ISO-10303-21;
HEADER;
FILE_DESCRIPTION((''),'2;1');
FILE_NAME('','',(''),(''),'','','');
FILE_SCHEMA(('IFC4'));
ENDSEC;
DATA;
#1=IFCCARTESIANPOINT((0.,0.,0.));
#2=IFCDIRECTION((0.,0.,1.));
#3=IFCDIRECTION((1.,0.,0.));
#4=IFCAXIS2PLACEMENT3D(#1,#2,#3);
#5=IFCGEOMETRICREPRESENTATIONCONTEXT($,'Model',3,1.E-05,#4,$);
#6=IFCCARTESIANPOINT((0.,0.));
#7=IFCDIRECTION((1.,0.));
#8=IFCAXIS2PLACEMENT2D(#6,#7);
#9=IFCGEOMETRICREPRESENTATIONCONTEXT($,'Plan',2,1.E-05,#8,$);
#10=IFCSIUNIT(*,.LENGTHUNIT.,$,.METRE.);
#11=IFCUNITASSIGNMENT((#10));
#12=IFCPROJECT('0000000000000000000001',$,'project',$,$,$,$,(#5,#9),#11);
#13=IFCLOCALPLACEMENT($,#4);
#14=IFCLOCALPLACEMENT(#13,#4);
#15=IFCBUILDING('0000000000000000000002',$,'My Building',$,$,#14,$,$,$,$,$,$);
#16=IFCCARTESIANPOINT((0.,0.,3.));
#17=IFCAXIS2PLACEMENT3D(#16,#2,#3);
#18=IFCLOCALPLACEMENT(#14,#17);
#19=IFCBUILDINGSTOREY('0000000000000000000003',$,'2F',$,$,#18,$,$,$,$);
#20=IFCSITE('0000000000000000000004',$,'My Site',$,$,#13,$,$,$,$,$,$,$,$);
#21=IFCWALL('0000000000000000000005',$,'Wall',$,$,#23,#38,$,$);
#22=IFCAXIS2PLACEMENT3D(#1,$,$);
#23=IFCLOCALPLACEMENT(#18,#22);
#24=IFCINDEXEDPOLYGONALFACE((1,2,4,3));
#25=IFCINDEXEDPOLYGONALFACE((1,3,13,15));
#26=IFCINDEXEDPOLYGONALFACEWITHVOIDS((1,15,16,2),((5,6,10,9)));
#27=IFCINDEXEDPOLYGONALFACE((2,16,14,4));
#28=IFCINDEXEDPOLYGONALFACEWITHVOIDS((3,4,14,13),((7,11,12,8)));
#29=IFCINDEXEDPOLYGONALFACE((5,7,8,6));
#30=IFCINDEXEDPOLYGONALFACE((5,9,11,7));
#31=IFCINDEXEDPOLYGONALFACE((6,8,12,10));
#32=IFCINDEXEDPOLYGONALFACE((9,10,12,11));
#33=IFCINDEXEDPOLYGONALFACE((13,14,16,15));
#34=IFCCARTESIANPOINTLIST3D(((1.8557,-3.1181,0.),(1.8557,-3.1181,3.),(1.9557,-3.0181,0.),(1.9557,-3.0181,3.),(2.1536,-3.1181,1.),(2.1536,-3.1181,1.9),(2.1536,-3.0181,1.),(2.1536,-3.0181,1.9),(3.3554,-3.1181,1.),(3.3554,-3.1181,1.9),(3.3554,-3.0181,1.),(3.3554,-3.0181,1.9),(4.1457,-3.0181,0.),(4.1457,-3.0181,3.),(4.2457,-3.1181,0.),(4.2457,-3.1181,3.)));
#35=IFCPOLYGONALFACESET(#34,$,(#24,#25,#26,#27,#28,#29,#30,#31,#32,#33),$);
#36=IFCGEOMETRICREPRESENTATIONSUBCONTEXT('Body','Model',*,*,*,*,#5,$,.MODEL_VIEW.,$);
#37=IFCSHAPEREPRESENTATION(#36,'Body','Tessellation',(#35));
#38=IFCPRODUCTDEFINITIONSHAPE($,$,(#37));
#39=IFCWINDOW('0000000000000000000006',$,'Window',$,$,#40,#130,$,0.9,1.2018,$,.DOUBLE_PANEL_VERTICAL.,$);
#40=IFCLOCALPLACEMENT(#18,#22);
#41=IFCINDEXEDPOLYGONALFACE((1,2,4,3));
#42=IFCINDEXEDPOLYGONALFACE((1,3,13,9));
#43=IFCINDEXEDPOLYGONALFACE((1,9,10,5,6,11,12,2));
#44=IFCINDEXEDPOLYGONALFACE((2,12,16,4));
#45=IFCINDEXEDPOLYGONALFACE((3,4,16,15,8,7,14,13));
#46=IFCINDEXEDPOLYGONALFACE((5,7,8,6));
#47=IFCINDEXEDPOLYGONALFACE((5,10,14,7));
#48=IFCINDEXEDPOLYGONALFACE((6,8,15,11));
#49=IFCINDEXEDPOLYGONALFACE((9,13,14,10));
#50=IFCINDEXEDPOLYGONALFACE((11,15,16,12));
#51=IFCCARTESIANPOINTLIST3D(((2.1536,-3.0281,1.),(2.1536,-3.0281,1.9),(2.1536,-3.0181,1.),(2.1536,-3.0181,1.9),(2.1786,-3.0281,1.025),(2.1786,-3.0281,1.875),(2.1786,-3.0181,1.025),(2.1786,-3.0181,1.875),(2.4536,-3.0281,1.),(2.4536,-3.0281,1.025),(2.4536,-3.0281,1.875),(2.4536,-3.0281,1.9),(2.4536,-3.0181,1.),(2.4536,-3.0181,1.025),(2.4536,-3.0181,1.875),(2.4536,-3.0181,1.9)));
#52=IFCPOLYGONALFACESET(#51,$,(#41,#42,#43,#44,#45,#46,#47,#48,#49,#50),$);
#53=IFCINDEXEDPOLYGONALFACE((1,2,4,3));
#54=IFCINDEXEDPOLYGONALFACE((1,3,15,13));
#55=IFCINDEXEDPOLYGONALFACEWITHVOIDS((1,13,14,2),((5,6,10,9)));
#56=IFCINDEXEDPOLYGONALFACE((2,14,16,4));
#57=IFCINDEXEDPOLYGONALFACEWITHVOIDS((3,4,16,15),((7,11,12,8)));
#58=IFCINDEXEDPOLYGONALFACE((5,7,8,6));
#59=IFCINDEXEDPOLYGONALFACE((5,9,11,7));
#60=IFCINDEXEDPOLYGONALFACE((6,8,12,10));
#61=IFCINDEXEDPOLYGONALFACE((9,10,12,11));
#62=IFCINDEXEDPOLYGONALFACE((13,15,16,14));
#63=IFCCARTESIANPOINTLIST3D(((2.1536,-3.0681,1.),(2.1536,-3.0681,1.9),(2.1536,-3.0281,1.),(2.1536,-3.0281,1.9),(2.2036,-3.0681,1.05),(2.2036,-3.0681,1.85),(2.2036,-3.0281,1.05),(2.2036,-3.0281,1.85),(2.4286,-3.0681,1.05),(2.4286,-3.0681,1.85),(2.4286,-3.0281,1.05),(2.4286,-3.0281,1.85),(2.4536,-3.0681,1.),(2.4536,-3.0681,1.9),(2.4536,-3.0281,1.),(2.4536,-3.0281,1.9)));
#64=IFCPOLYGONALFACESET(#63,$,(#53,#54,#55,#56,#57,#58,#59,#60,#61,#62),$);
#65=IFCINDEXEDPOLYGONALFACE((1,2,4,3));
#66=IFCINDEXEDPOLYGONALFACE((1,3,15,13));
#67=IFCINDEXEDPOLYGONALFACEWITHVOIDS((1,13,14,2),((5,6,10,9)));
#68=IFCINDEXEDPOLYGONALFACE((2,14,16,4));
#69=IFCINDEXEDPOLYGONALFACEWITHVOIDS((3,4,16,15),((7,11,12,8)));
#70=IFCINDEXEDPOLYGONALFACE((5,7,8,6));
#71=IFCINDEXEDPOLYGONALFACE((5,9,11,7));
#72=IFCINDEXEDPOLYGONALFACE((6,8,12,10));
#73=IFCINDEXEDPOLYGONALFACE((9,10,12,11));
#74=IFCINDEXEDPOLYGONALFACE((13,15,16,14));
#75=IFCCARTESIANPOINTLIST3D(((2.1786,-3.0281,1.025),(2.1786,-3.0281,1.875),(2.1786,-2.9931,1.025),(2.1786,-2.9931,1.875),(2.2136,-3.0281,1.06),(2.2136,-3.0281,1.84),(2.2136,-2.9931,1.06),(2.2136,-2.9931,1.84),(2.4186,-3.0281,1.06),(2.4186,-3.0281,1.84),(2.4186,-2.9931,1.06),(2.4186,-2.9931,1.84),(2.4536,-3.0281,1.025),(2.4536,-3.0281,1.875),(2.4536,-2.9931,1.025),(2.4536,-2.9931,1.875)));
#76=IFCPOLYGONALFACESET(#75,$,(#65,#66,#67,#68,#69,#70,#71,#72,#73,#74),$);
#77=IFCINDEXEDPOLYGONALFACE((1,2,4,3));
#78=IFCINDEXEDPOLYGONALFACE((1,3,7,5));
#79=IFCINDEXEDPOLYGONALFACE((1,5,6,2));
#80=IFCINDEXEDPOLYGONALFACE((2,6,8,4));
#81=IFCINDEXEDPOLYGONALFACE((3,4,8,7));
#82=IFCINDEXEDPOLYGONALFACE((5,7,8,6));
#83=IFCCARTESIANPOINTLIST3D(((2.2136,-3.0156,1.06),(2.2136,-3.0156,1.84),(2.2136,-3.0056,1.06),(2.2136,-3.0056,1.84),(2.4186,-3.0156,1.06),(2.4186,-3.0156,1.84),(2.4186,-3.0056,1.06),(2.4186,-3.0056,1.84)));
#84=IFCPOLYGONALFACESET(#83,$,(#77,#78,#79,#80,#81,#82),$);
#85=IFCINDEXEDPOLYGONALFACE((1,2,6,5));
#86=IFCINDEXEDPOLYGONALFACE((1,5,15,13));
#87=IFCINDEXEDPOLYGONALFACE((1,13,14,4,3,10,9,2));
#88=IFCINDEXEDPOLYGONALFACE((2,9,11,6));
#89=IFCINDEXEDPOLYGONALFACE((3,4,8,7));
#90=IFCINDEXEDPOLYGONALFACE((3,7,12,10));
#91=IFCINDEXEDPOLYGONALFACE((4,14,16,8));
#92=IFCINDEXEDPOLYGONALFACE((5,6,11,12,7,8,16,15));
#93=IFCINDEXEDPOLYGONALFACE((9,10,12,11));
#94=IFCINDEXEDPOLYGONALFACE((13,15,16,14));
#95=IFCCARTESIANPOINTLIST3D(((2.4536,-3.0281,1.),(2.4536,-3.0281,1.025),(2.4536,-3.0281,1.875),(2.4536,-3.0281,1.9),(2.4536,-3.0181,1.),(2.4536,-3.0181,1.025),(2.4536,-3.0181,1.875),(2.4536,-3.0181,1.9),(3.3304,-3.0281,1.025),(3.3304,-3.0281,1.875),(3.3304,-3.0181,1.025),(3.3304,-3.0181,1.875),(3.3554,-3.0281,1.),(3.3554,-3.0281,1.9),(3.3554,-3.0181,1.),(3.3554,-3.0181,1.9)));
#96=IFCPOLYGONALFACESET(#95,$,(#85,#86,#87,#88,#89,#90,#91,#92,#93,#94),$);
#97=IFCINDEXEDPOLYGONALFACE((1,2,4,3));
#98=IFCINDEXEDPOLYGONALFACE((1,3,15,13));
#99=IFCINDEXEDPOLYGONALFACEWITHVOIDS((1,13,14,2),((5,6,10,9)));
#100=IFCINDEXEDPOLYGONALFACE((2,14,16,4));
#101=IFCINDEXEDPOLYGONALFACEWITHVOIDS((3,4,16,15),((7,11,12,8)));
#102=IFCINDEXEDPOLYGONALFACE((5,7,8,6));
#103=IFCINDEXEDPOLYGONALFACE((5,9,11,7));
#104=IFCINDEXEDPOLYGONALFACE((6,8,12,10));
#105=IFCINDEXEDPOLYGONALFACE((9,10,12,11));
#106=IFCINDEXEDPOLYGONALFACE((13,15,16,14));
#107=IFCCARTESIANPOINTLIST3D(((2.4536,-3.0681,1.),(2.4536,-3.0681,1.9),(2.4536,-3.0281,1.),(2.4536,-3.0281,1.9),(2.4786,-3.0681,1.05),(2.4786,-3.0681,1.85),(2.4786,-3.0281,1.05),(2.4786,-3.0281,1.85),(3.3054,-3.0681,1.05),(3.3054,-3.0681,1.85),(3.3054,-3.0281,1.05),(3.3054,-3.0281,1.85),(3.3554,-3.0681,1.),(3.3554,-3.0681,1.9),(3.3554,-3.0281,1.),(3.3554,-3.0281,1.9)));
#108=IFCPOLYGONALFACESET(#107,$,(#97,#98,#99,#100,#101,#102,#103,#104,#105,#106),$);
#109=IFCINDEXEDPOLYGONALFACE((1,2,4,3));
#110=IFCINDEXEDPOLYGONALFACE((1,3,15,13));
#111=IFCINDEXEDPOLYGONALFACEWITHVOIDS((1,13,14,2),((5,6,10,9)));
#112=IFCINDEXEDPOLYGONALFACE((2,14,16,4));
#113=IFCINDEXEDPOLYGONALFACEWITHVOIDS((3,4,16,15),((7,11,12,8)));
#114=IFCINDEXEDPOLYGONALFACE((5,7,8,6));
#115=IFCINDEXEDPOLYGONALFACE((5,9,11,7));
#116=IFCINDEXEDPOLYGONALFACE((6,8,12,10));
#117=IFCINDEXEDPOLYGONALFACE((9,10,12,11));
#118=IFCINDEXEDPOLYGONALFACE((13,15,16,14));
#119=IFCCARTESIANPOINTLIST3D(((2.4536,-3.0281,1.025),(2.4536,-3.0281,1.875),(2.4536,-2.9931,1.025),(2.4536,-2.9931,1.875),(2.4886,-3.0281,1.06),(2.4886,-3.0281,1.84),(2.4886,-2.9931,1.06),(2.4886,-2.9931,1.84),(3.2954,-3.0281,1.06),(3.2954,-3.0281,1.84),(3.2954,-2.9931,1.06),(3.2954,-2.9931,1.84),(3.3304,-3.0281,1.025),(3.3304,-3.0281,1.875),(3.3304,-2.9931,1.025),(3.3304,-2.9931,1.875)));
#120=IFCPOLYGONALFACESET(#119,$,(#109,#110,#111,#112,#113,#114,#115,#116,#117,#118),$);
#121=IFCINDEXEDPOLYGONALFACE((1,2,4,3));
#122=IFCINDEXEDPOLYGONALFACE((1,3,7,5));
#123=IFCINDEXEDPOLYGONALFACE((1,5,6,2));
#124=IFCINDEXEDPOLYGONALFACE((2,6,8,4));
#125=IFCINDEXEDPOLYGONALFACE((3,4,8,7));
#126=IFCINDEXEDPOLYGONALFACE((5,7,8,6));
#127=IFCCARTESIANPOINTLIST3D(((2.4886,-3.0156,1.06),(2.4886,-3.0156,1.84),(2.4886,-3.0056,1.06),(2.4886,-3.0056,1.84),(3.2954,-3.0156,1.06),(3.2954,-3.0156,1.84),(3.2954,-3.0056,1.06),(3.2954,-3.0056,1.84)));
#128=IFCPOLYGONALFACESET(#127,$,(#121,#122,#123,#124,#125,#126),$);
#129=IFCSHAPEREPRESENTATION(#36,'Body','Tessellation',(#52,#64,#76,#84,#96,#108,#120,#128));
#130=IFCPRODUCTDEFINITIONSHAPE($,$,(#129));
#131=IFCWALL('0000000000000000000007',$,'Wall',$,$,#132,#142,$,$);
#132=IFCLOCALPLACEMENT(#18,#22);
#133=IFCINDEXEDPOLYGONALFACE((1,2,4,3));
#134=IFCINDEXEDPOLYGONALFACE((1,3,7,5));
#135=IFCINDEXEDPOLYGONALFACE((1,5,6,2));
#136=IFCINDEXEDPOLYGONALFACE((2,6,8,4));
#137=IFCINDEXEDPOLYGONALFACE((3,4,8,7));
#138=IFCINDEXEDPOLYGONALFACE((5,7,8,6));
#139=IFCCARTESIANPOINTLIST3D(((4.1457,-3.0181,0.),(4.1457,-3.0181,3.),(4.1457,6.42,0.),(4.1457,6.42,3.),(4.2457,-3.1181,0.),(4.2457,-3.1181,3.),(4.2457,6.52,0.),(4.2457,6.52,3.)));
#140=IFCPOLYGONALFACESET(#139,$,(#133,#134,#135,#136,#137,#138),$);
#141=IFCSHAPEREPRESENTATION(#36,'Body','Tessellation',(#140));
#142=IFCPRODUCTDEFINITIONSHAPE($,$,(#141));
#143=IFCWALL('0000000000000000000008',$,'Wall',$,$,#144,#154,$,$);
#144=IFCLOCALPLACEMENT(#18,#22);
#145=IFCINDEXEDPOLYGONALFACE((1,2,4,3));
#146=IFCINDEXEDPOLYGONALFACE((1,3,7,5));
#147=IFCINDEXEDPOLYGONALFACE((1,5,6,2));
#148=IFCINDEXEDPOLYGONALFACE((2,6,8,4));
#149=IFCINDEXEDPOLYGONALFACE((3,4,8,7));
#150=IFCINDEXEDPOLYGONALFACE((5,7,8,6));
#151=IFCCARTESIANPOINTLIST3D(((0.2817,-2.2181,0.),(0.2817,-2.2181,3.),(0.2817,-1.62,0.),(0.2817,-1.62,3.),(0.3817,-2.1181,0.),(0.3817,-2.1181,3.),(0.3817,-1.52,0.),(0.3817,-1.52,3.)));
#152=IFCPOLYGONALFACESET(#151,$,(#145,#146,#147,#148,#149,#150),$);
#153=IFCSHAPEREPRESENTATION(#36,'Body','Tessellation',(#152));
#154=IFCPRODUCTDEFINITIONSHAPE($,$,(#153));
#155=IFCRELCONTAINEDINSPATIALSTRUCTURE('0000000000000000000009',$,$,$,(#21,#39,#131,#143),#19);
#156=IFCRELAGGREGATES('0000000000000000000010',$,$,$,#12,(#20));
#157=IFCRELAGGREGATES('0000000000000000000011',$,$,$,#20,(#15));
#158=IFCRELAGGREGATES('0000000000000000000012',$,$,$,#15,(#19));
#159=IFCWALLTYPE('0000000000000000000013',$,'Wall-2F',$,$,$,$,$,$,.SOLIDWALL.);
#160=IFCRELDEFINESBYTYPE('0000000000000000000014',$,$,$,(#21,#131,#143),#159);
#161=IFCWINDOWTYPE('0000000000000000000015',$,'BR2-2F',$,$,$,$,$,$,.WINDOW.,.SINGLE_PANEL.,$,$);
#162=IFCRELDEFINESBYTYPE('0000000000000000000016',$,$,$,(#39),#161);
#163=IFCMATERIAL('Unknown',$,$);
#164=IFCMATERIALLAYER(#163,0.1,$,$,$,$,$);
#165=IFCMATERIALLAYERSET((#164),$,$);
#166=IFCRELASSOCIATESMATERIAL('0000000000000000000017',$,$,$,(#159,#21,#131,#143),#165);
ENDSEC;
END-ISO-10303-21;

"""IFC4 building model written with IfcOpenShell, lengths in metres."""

from ifc_helpers import new_model, entity, si_unit, frame, origin_with_axes, origin_2d_with_axis, place, context, subcontext, project, spatial, line, indexed_curve, outline, extrude, shape, source, transform, mapped, material, layer, layer_set, layer_usage, type_object, type_shapes, element, fill, save


model = new_model("IFC4")

# Units and contexts
model_context = context("Model", 3, precision=1e-05, world=origin_with_axes())
plan_context = context("Plan", 2, precision=1e-05, world=origin_2d_with_axis())
body_context_1 = subcontext(model_context, "Body", "Model", "MODEL_VIEW")
body_context_2 = subcontext(plan_context, "Body", "Plan", "PLAN_VIEW")
ifc_project = project(units=[si_unit("LENGTHUNIT", "METRE")], contexts=[model_context, plan_context])

# Site, building, storey
site_placement = place(None, origin_with_axes())
site = spatial("IfcSite", under=ifc_project, at=site_placement, Name="My Site")
building_placement = place(site_placement, origin_with_axes())
building = spatial("IfcBuilding", under=site, at=building_placement, Name="My Building")
storey_placement = place(building_placement, frame((0.0, 0.0, 3.0), z_axis=(0.0, 0.0, 1.0), x_axis=(1.0, 0.0, 0.0)))
storey = spatial("IfcBuildingStorey", under=building, at=storey_placement, Name="2F")

# Shared definitions
ifc_material = material(Name="Unknown")

# Shared definitions
ifc_layer_1 = layer(ifc_material, 0.1)
ifc_layer_set_1 = layer_set([ifc_layer_1])
wall_type_1 = type_object("IfcWallType", Name="Wall-2F", PredefinedType="SOLIDWALL", material=ifc_layer_set_1)

# Wall, opening, window
ifc_layer_usage_1 = layer_usage(ifc_layer_set_1, "AXIS2", "POSITIVE", 0.0)
wall_1_placement = place(storey_placement, frame((1.8557, -3.1181, 0.0), z_axis=(0.0, 0.0, 1.0), x_axis=(1.0, 0.0, 0.0)))
wall_1 = element("IfcWall", 1, at=wall_1_placement, inside=storey, type_object=wall_type_1, material=ifc_layer_usage_1, Name="Wall", context=body_context_1, shape_type="SweptSolid", body=[
    extrude(outline(indexed_curve([(0.0, 0.0), (0.1, 0.1), (2.29, 0.1), (2.39, 0.0)], segments=[line(1, 2, 3, 4, 1)])), origin_with_axes(), (0.0, 0.0, 1.0), 3.0),
])
shared_shape_1 = source(origin_with_axes(), body_context_1, "Body", "SweptSolid", [
    extrude(outline(indexed_curve([(0.0, 0.0), (1.2018, 0.0), (1.2018, 0.9), (0.0, 0.9)], segments=[line(1, 2, 3, 4, 1)])), frame((0.0, -0.6, 0.0), z_axis=(0.0, -1.0, 0.0), x_axis=(1.0, 0.0, 0.0)), (0.0, 0.0, -1.0), 1.2),
])
opening_1_placement = place(wall_1_placement, frame((0.2979, 0.0, 1.0), z_axis=(0.0, 0.0, 1.0), x_axis=(1.0, 0.0, 0.0)))
opening_1 = element("IfcOpeningElement", 2, at=opening_1_placement, cuts=wall_1, PredefinedType="OPENING", context=body_context_1, shape_type="MappedRepresentation", body=[
    mapped(shared_shape_1, transform((0.0, 0.0, 0.0), x_axis=(1.0, 0.0, 0.0), y_axis=(0.0, 1.0, 0.0), z_axis=(0.0, 0.0, 1.0), scale=1.0)),
])
window_type = type_object("IfcWindowType", Name="BR2-2F", PartitioningType="SINGLE_PANEL", PredefinedType="WINDOW")
shared_shape_2 = source(origin_with_axes(), body_context_1, "Body", "SweptSolid", [
    extrude(outline(indexed_curve([(0.3, 0.0), (0.0, 0.0), (0.0, 0.9), (0.3, 0.9), (0.3, 0.875), (0.025, 0.875), (0.025, 0.025), (0.3, 0.025)], segments=[line(1, 2, 3, 4, 5, 6, 7, 8, 1)])), frame((0.0, 0.09, 0.0), z_axis=(0.0, -1.0, 0.0), x_axis=(1.0, 0.0, 0.0)), (0.0, 0.0, -1.0), 0.01),
    extrude(outline(indexed_curve([(0.0, 0.0), (0.3, 0.0), (0.3, 0.9), (0.0, 0.9)], segments=[line(1, 2, 3, 4, 1)]), holes=[indexed_curve([(0.05, 0.05), (0.275, 0.05), (0.275, 0.85), (0.05, 0.85)], segments=[line(1, 2, 3, 4, 1)])]), frame((0.0, 0.05, 0.0), z_axis=(0.0, -1.0, 0.0), x_axis=(1.0, 0.0, 0.0)), (0.0, 0.0, -1.0), 0.04),
    extrude(outline(indexed_curve([(0.0, 0.0), (0.275, 0.0), (0.275, 0.85), (0.0, 0.85)], segments=[line(1, 2, 3, 4, 1)]), holes=[indexed_curve([(0.035, 0.035), (0.24, 0.035), (0.24, 0.815), (0.035, 0.815)], segments=[line(1, 2, 3, 4, 1)])]), frame((0.025, 0.09, 0.025), z_axis=(0.0, -1.0, 0.0), x_axis=(1.0, 0.0, 0.0)), (0.0, 0.0, -1.0), 0.035),
    extrude(outline(indexed_curve([(0.035, 0.035), (0.24, 0.035), (0.24, 0.815), (0.035, 0.815)], segments=[line(1, 2, 3, 4, 1)])), frame((0.025, 0.1025, 0.025), z_axis=(0.0, -1.0, 0.0), x_axis=(1.0, 0.0, 0.0)), (0.0, 0.0, -1.0), 0.01),
    extrude(outline(indexed_curve([(0.0, 0.9), (0.9018, 0.9), (0.9018, 0.0), (0.0, 0.0), (0.0, 0.025), (0.8768, 0.025), (0.8768, 0.875), (0.0, 0.875)], segments=[line(1, 2, 3, 4, 5, 6, 7, 8, 1)])), frame((0.3, 0.09, 0.0), z_axis=(0.0, -1.0, 0.0), x_axis=(1.0, 0.0, 0.0)), (0.0, 0.0, -1.0), 0.01),
    extrude(outline(indexed_curve([(0.0, 0.0), (0.9018, 0.0), (0.9018, 0.9), (0.0, 0.9)], segments=[line(1, 2, 3, 4, 1)]), holes=[indexed_curve([(0.025, 0.05), (0.8518, 0.05), (0.8518, 0.85), (0.025, 0.85)], segments=[line(1, 2, 3, 4, 1)])]), frame((0.3, 0.05, 0.0), z_axis=(0.0, -1.0, 0.0), x_axis=(1.0, 0.0, 0.0)), (0.0, 0.0, -1.0), 0.04),
    extrude(outline(indexed_curve([(0.0, 0.0), (0.8768, 0.0), (0.8768, 0.85), (0.0, 0.85)], segments=[line(1, 2, 3, 4, 1)]), holes=[indexed_curve([(0.035, 0.035), (0.8418, 0.035), (0.8418, 0.815), (0.035, 0.815)], segments=[line(1, 2, 3, 4, 1)])]), frame((0.3, 0.09, 0.025), z_axis=(0.0, -1.0, 0.0), x_axis=(1.0, 0.0, 0.0)), (0.0, 0.0, -1.0), 0.035),
    extrude(outline(indexed_curve([(0.035, 0.035), (0.8418, 0.035), (0.8418, 0.815), (0.035, 0.815)], segments=[line(1, 2, 3, 4, 1)])), frame((0.3, 0.1025, 0.025), z_axis=(0.0, -1.0, 0.0), x_axis=(1.0, 0.0, 0.0)), (0.0, 0.0, -1.0), 0.01),
])
shared_shape_3 = source(origin_with_axes(), body_context_2, "Body", "Curve2D", [
    entity("IfcIndexedPolyCurve", entity("IfcCartesianPointList2D", [[0.05, 0.05], [0.275, 0.05]])),
    entity("IfcIndexedPolyCurve", entity("IfcCartesianPointList2D", [[0.0, 0.1], [0.025, 0.1], [0.025, 0.09], [0.05, 0.09], [0.05, 0.05], [0.0, 0.05]]), [entity("IfcLineIndex", [1, 2, 3, 4, 5, 6, 1])]),
    entity("IfcIndexedPolyCurve", entity("IfcCartesianPointList2D", [[0.3, 0.1], [0.3, 0.1], [0.3, 0.09], [0.275, 0.09], [0.275, 0.05], [0.3, 0.05]])),
    entity("IfcIndexedPolyCurve", entity("IfcCartesianPointList2D", [[0.025, 0.09], [0.06, 0.09], [0.06, 0.125], [0.025, 0.125]]), [entity("IfcLineIndex", [1, 2, 3, 4, 1])]),
    entity("IfcIndexedPolyCurve", entity("IfcCartesianPointList2D", [[0.3, 0.09], [0.265, 0.09], [0.265, 0.125], [0.3, 0.125]]), [entity("IfcLineIndex", [1, 2, 3, 4, 1])]),
    entity("IfcIndexedPolyCurve", entity("IfcCartesianPointList2D", [[0.06, 0.09], [0.265, 0.09]])),
    entity("IfcIndexedPolyCurve", entity("IfcCartesianPointList2D", [[0.06, 0.125], [0.265, 0.125]])),
    entity("IfcIndexedPolyCurve", entity("IfcCartesianPointList2D", [[0.06, 0.1075], [0.265, 0.1075]])),
    entity("IfcIndexedPolyCurve", entity("IfcCartesianPointList2D", [[0.325, 0.05], [1.1518, 0.05]])),
    entity("IfcIndexedPolyCurve", entity("IfcCartesianPointList2D", [[0.3, 0.1], [0.3, 0.1], [0.3, 0.09], [0.325, 0.09], [0.325, 0.05], [0.3, 0.05]])),
    entity("IfcIndexedPolyCurve", entity("IfcCartesianPointList2D", [[1.2018, 0.1], [1.1768, 0.1], [1.1768, 0.09], [1.1518, 0.09], [1.1518, 0.05], [1.2018, 0.05]]), [entity("IfcLineIndex", [1, 2, 3, 4, 5, 6, 1])]),
    entity("IfcIndexedPolyCurve", entity("IfcCartesianPointList2D", [[0.3, 0.09], [0.335, 0.09], [0.335, 0.125], [0.3, 0.125]]), [entity("IfcLineIndex", [1, 2, 3, 4, 1])]),
    entity("IfcIndexedPolyCurve", entity("IfcCartesianPointList2D", [[1.1768, 0.09], [1.1418, 0.09], [1.1418, 0.125], [1.1768, 0.125]]), [entity("IfcLineIndex", [1, 2, 3, 4, 1])]),
    entity("IfcIndexedPolyCurve", entity("IfcCartesianPointList2D", [[0.335, 0.09], [1.1418, 0.09]])),
    entity("IfcIndexedPolyCurve", entity("IfcCartesianPointList2D", [[0.335, 0.125], [1.1418, 0.125]])),
    entity("IfcIndexedPolyCurve", entity("IfcCartesianPointList2D", [[0.335, 0.1075], [1.1418, 0.1075]])),
])
type_shapes(window_type, [shared_shape_2, shared_shape_3])
window_placement = place(opening_1_placement, origin_with_axes())
window = element("IfcWindow", 3, at=window_placement, inside=storey, type_object=window_type, Name="Window", OverallHeight=0.9, OverallWidth=1.2018, PartitioningType="DOUBLE_PANEL_VERTICAL", shapes=[
    shape(body_context_1, "Body", "MappedRepresentation", [mapped(shared_shape_2, transform((0.0, 0.0, 0.0), x_axis=(1.0, 0.0, 0.0), y_axis=(0.0, 1.0, 0.0), z_axis=(0.0, 0.0, 1.0), scale=1.0))]),
    shape(body_context_2, "Body", "MappedRepresentation", [mapped(shared_shape_3, transform((0.0, 0.0, 0.0), x_axis=(1.0, 0.0, 0.0), y_axis=(0.0, 1.0, 0.0), z_axis=(0.0, 0.0, 1.0), scale=1.0))]),
])
fill(opening_1, window)

# Walls
ifc_layer_usage_2 = layer_usage(ifc_layer_set_1, "AXIS2", "POSITIVE", 0.0)
wall_2_placement = place(storey_placement, frame((4.2457, -3.1181, 0.0), z_axis=(0.0, 0.0, 1.0), x_axis=(0.0, 1.0, 0.0)))
element("IfcWall", 4, at=wall_2_placement, inside=storey, type_object=wall_type_1, material=ifc_layer_usage_2, Name="Wall", context=body_context_1, shape_type="SweptSolid", body=[
    extrude(outline(indexed_curve([(0.0, 0.0), (0.1, 0.1), (9.5381, 0.1), (9.6381, 0.0)], segments=[line(1, 2, 3, 4, 1)])), origin_with_axes(), (0.0, 0.0, 1.0), 3.0),
])
ifc_layer_usage_3 = layer_usage(ifc_layer_set_1, "AXIS2", "POSITIVE", 0.0)
wall_3_placement = place(storey_placement, frame((0.2817, -1.62, 0.0), z_axis=(0.0, 0.0, 1.0), x_axis=(0.0, -1.0, 0.0)))
element("IfcWall", 5, at=wall_3_placement, inside=storey, type_object=wall_type_1, material=ifc_layer_usage_3, Name="Wall", context=body_context_1, shape_type="SweptSolid", body=[
    extrude(outline(indexed_curve([(0.0, 0.0), (-0.1, 0.1), (0.4981, 0.1), (0.5981, 0.0)], segments=[line(1, 2, 3, 4, 1)])), origin_with_axes(), (0.0, 0.0, 1.0), 3.0),
])

save(model, "model.ifc")
